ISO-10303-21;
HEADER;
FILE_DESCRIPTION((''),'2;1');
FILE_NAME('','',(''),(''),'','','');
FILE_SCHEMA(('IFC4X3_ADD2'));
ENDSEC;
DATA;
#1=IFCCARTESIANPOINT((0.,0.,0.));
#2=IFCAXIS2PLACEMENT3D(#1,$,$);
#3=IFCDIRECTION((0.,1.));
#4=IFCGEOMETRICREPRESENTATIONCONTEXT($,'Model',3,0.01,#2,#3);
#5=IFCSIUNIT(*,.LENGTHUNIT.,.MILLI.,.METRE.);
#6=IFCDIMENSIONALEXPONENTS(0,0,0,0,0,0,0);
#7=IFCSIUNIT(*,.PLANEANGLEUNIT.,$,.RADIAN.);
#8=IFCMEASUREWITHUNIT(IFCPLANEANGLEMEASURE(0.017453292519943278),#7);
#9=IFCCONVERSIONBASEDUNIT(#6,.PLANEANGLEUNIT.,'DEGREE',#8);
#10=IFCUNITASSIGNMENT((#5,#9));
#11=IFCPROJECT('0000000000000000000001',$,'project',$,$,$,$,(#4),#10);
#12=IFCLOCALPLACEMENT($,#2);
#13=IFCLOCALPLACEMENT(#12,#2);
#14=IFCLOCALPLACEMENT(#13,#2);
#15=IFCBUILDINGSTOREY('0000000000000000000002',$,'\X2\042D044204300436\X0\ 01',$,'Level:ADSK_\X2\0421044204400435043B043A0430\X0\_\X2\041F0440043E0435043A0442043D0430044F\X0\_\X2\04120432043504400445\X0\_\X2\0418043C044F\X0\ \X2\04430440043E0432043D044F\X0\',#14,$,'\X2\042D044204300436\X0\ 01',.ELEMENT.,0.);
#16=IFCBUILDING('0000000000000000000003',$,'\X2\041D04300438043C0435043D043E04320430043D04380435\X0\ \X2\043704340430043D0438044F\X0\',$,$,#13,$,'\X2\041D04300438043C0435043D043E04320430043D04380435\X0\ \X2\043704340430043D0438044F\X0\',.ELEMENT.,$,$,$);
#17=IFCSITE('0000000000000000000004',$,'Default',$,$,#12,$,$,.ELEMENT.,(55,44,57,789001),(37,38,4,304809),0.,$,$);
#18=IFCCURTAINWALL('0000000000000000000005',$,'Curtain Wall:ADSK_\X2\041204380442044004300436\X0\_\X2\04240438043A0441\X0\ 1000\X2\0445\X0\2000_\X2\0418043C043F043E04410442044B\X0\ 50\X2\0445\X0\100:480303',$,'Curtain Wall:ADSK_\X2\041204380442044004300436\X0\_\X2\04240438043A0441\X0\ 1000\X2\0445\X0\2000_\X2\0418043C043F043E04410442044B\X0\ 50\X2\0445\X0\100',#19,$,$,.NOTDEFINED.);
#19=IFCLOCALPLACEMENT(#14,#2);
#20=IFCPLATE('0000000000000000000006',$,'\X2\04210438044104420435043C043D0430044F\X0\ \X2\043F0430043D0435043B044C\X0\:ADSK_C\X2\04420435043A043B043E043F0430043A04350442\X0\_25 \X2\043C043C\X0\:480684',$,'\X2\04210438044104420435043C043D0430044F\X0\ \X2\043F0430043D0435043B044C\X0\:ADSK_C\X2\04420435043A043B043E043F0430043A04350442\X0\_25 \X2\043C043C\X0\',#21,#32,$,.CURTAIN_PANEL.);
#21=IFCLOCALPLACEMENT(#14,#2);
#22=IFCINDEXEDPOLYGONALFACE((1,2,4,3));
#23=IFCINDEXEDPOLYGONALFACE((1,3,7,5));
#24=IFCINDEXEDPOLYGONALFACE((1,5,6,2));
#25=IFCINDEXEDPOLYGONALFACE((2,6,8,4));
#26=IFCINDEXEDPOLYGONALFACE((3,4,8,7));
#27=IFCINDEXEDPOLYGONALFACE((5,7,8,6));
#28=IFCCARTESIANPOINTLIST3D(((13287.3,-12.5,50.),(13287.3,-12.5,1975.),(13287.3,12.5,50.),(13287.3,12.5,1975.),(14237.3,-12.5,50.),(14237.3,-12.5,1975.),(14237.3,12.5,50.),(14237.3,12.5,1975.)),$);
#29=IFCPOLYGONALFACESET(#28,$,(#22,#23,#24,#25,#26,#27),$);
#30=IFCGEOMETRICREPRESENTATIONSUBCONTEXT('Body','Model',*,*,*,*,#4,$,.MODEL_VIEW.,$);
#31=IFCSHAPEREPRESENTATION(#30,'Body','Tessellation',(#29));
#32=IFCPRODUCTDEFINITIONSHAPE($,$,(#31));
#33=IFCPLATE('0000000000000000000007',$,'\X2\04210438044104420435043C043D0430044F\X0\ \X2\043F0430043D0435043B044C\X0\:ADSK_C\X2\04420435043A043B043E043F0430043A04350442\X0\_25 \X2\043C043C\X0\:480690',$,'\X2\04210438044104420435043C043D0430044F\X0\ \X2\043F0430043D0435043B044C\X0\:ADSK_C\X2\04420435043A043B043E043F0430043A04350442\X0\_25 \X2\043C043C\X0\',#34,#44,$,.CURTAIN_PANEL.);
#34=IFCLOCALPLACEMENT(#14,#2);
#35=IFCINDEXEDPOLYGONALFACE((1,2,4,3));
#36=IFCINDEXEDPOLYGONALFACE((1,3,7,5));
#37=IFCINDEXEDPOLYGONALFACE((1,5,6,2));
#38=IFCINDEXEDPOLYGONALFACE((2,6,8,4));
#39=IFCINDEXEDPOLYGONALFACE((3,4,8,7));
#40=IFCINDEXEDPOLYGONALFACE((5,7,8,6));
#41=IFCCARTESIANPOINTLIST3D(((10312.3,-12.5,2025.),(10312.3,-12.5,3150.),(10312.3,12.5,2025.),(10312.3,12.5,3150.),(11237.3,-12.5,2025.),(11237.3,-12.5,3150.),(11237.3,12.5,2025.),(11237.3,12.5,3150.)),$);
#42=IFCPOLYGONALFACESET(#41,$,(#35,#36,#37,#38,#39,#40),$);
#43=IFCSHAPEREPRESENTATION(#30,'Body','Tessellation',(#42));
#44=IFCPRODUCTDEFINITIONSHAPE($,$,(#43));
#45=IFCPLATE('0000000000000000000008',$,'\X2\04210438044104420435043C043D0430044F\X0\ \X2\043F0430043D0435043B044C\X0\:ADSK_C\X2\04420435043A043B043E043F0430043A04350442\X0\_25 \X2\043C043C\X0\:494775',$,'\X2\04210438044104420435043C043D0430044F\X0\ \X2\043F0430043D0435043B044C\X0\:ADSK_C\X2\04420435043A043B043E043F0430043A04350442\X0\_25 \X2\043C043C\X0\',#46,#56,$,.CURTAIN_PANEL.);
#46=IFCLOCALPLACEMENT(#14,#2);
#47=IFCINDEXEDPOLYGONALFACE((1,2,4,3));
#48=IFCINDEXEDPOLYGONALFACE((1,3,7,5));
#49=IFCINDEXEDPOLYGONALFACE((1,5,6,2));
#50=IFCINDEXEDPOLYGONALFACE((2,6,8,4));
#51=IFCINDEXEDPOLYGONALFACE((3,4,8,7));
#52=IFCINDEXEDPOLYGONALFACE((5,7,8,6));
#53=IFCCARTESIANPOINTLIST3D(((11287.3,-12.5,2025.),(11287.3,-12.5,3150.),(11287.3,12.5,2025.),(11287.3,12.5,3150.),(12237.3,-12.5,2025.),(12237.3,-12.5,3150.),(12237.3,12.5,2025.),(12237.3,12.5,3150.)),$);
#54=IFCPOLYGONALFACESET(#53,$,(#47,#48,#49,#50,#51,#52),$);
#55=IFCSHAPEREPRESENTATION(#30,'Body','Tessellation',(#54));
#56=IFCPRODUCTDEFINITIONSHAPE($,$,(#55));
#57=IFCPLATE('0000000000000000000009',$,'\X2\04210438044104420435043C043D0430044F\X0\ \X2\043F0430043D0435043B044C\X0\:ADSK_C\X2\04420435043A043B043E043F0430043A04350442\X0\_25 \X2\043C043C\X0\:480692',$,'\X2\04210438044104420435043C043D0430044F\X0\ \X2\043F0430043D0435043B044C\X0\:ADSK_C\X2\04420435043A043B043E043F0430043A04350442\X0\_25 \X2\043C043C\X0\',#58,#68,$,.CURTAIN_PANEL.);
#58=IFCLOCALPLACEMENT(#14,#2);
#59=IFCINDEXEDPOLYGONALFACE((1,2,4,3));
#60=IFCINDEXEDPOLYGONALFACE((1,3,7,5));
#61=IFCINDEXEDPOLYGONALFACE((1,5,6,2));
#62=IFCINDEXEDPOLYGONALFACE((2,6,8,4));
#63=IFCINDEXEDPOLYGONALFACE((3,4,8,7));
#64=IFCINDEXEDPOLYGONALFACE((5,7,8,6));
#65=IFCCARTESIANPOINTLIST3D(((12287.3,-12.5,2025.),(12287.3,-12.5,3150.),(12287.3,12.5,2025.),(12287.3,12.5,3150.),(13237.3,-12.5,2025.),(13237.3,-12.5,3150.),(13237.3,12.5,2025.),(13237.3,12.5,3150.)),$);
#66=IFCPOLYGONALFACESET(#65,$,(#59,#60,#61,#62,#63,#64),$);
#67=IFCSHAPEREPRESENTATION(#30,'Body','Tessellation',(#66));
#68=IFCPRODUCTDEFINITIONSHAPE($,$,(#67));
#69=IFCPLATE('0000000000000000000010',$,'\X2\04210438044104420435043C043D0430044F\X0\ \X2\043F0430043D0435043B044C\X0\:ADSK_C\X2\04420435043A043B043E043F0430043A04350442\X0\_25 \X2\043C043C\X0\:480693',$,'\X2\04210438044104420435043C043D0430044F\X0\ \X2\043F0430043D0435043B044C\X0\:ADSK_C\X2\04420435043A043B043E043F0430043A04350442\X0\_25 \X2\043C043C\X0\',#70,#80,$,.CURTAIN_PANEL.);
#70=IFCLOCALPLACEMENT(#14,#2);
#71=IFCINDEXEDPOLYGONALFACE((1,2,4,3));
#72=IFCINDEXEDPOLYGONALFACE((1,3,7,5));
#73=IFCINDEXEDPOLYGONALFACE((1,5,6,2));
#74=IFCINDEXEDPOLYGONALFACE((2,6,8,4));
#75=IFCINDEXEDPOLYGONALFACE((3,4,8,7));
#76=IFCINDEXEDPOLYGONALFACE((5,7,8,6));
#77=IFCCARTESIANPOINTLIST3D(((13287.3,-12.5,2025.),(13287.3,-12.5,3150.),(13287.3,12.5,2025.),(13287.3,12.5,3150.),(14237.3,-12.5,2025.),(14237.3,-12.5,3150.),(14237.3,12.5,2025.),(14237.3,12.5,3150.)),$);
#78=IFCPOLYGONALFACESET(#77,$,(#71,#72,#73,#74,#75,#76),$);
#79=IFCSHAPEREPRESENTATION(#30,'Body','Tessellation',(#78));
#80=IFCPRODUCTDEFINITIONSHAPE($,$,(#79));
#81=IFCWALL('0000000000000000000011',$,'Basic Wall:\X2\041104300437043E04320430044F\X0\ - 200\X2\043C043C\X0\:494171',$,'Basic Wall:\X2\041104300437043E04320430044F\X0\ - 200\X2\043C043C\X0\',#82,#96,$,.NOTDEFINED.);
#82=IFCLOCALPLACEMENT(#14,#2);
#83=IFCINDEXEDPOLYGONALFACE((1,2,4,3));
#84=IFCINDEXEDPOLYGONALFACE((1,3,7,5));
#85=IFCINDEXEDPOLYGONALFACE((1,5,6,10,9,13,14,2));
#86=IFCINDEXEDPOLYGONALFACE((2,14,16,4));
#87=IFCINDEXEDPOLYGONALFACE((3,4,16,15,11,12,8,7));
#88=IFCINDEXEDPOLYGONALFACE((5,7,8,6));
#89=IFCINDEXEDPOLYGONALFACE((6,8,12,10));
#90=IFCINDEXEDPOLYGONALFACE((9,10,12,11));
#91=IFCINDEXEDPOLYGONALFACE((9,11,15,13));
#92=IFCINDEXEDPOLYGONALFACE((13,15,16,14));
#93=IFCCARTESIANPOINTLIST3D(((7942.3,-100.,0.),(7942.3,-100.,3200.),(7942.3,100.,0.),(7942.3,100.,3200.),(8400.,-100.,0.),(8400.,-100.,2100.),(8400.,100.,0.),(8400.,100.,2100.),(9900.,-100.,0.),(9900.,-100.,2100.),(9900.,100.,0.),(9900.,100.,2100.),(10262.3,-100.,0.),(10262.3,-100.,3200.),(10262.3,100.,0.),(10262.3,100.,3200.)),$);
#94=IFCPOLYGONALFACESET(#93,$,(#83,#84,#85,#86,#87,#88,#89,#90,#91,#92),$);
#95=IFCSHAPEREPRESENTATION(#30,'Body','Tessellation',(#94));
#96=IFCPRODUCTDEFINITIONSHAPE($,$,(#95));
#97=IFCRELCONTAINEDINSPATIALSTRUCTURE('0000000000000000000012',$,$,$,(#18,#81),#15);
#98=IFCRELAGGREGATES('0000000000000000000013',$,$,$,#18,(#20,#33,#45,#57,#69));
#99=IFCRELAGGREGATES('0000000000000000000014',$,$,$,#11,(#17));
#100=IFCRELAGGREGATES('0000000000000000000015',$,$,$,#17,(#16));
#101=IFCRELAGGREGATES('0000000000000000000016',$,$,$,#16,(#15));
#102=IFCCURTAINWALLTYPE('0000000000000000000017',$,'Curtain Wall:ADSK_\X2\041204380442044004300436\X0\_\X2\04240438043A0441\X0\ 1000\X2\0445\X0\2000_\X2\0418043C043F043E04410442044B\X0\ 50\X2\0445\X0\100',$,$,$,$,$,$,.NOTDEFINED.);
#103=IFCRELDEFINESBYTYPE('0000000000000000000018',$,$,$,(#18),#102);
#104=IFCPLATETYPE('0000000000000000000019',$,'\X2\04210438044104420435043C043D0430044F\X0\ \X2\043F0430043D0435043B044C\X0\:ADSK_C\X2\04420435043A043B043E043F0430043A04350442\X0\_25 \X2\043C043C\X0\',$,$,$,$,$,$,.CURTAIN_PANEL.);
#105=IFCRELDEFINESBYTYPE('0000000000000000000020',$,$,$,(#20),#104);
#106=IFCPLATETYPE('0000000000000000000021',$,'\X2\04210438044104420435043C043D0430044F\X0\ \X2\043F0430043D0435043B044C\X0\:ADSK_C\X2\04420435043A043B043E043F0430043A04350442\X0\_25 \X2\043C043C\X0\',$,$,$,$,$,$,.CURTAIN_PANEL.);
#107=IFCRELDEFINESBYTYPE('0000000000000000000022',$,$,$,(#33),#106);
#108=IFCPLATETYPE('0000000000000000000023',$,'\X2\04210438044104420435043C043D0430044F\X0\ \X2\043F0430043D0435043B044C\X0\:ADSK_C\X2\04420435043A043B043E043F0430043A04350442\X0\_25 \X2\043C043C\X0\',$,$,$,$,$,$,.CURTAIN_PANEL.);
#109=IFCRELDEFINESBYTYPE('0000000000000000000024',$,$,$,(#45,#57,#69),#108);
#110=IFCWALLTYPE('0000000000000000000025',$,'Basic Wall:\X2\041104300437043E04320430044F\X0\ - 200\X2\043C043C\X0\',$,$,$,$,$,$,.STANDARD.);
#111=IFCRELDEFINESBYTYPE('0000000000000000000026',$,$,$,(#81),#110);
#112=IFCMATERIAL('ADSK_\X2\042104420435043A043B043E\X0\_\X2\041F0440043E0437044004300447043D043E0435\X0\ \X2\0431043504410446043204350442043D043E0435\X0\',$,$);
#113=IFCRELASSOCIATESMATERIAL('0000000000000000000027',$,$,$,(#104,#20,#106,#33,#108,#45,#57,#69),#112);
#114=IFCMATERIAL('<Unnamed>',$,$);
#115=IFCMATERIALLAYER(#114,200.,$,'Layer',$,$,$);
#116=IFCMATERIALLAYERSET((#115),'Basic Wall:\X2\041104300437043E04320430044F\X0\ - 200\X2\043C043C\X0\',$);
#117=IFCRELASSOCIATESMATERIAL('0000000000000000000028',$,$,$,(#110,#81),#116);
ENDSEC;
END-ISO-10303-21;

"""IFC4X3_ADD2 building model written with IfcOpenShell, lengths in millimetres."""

from ifc_helpers import new_model, entity, si_unit, converted_unit, direction, frame, frame_2d, origin, origin_2d_with_axis, place, context, subcontext, project, spatial, rectangle, extrude, source, transform, mapped, material, layer, layer_set, type_object, type_shapes, element, aggregate, save


model = new_model("IFC4X3_ADD2")

# Units and contexts
model_context = context("Model", 3, precision=0.01, world=origin(), true_north=direction((0.0, 1.0)))
body_context = subcontext(model_context, "Body", "Model", "MODEL_VIEW")
ifc_project = project(units=[si_unit("LENGTHUNIT", "METRE", prefix="MILLI"), converted_unit("PLANEANGLEUNIT", "DEGREE", entity("IfcPlaneAngleMeasure", 0.017453292519943278), si_unit("PLANEANGLEUNIT", "RADIAN"), dimensions=[0, 0, 0, 0, 0, 0, 0])], contexts=[model_context])

# Site, building, storey
site_placement = place(None, origin())
site = spatial("IfcSite", under=ifc_project, at=site_placement, Name="Default", CompositionType="ELEMENT", RefLatitude=(55, 44, 57, 789001), RefLongitude=(37, 38, 4, 304809), RefElevation=0.0)
building_placement = place(site_placement, origin())
building = spatial("IfcBuilding", under=site, at=building_placement, Name="Наименование здания", LongName="Наименование здания", CompositionType="ELEMENT")
storey_placement = place(building_placement, origin())
storey = spatial("IfcBuildingStorey", under=building, at=storey_placement, Name="Этаж 01", ObjectType="Level:ADSK_Стрелка_Проектная_Вверх_Имя уровня", LongName="Этаж 01", CompositionType="ELEMENT", Elevation=0.0)

# Shared definitions
curtain_wall_type = type_object("IfcCurtainWallType", Name="Curtain Wall:ADSK_Витраж_Фикс 1000х2000_Импосты 50х100", PredefinedType="NOTDEFINED")
ifc_material_1 = material(Name="ADSK_Стекло_Прозрачное бесцветное")

# Curtain wall
curtain_wall_1_placement = place(storey_placement, origin())
curtain_wall_1 = element("IfcCurtainWall", 1, at=curtain_wall_1_placement, inside=storey, type_object=curtain_wall_type, Name="Curtain Wall:ADSK_Витраж_Фикс 1000х2000_Импосты 50х100:480303", ObjectType="Curtain Wall:ADSK_Витраж_Фикс 1000х2000_Импосты 50х100", PredefinedType="NOTDEFINED")

# Plates
plate_type_1 = type_object("IfcPlateType", Name="Системная панель:ADSK_Cтеклопакет_25 мм", PredefinedType="CURTAIN_PANEL", material=ifc_material_1)
shared_shape_1 = source(origin(), body_context, "Body", "SweptSolid", [
    extrude(rectangle(XDim=25.0, YDim=950.0, at=origin_2d_with_axis()), frame((0.0, 0.0, 0.0), z_axis=(0.0, 0.0, 1.0), x_axis=(0.0, 1.0, 0.0)), (0.0, 0.0, 1.0), 1925.0),
])
type_shapes(plate_type_1, [shared_shape_1])
plate_1_placement = place(curtain_wall_1_placement, frame((13762.3, 0.0, 50.0)))
plate_1 = element("IfcPlate", 2, at=plate_1_placement, type_object=plate_type_1, material=ifc_material_1, Name="Системная панель:ADSK_Cтеклопакет_25 мм:480684", ObjectType="Системная панель:ADSK_Cтеклопакет_25 мм", PredefinedType="CURTAIN_PANEL", context=body_context, shape_type="MappedRepresentation", body=[
    mapped(shared_shape_1, transform((0.0, 0.0, 0.0), scale=1.0)),
])
plate_type_2 = type_object("IfcPlateType", Name="Системная панель:ADSK_Cтеклопакет_25 мм", PredefinedType="CURTAIN_PANEL", material=ifc_material_1)
shared_shape_2 = source(origin(), body_context, "Body", "SweptSolid", [
    extrude(rectangle(XDim=25.0, YDim=925.0, at=origin_2d_with_axis()), frame((0.0, 0.0, 0.0), z_axis=(0.0, 0.0, 1.0), x_axis=(0.0, 1.0, 0.0)), (0.0, 0.0, 1.0), 1125.0),
])
type_shapes(plate_type_2, [shared_shape_2])
plate_2_placement = place(curtain_wall_1_placement, frame((10774.8, 0.0, 2025.0)))
plate_2 = element("IfcPlate", 3, at=plate_2_placement, type_object=plate_type_2, material=ifc_material_1, Name="Системная панель:ADSK_Cтеклопакет_25 мм:480690", ObjectType="Системная панель:ADSK_Cтеклопакет_25 мм", PredefinedType="CURTAIN_PANEL", context=body_context, shape_type="MappedRepresentation", body=[
    mapped(shared_shape_2, transform((0.0, 0.0, 0.0), scale=1.0)),
])
plate_type_3 = type_object("IfcPlateType", Name="Системная панель:ADSK_Cтеклопакет_25 мм", PredefinedType="CURTAIN_PANEL", material=ifc_material_1)
shared_shape_3 = source(origin(), body_context, "Body", "SweptSolid", [
    extrude(rectangle(XDim=25.0, YDim=950.0, at=origin_2d_with_axis()), frame((0.0, 0.0, 0.0), z_axis=(0.0, 0.0, 1.0), x_axis=(0.0, 1.0, 0.0)), (0.0, 0.0, 1.0), 1125.0),
])
type_shapes(plate_type_3, [shared_shape_3])
plate_3_placement = place(curtain_wall_1_placement, frame((11762.3, 0.0, 2025.0)))
plate_3 = element("IfcPlate", 4, at=plate_3_placement, type_object=plate_type_3, material=ifc_material_1, Name="Системная панель:ADSK_Cтеклопакет_25 мм:494775", ObjectType="Системная панель:ADSK_Cтеклопакет_25 мм", PredefinedType="CURTAIN_PANEL", context=body_context, shape_type="MappedRepresentation", body=[
    mapped(shared_shape_3, transform((0.0, 0.0, 0.0), scale=1.0)),
])
plate_4_placement = place(curtain_wall_1_placement, frame((12762.3, 0.0, 2025.0)))
plate_4 = element("IfcPlate", 5, at=plate_4_placement, type_object=plate_type_3, material=ifc_material_1, Name="Системная панель:ADSK_Cтеклопакет_25 мм:480692", ObjectType="Системная панель:ADSK_Cтеклопакет_25 мм", PredefinedType="CURTAIN_PANEL", context=body_context, shape_type="MappedRepresentation", body=[
    mapped(shared_shape_3, transform((0.0, 0.0, 0.0), scale=1.0)),
])
plate_5_placement = place(curtain_wall_1_placement, frame((13762.3, 0.0, 2025.0)))
plate_5 = element("IfcPlate", 6, at=plate_5_placement, type_object=plate_type_3, material=ifc_material_1, Name="Системная панель:ADSK_Cтеклопакет_25 мм:480693", ObjectType="Системная панель:ADSK_Cтеклопакет_25 мм", PredefinedType="CURTAIN_PANEL", context=body_context, shape_type="MappedRepresentation", body=[
    mapped(shared_shape_3, transform((0.0, 0.0, 0.0), scale=1.0)),
])
aggregate(curtain_wall_1, [plate_1, plate_2, plate_3, plate_4, plate_5])

# Wall, opening
ifc_material_2 = material(Name="<Unnamed>")
ifc_layer = layer(ifc_material_2, 200.0, Name="Layer")
ifc_layer_set = layer_set([ifc_layer], Name="Basic Wall:Базовая - 200мм")
wall_type = type_object("IfcWallType", Name="Basic Wall:Базовая - 200мм", PredefinedType="STANDARD", material=ifc_layer_set)
wall_placement = place(storey_placement, frame((7942.3, 0.0, 0.0)))
wall = element("IfcWall", 7, at=wall_placement, inside=storey, type_object=wall_type, material=ifc_layer_set, Name="Basic Wall:Базовая - 200мм:494171", ObjectType="Basic Wall:Базовая - 200мм", PredefinedType="NOTDEFINED", context=body_context, shape_type="SweptSolid", body=[
    extrude(rectangle(XDim=2320.0, YDim=200.0, at=frame_2d((1160.0, 0.0), x_axis=(1.0, 0.0))), origin(), (0.0, 0.0, 1.0), 3200.0),
])
opening_placement = place(wall_placement, frame((-7942.3, 0.0, 0.0)))
element("IfcOpeningElement", 8, at=opening_placement, cuts=wall, PredefinedType="OPENING", context=body_context, shape_type="SweptSolid", body=[
    extrude(rectangle(XDim=2100.0, YDim=1500.0, at=frame_2d((0.0, 0.0), x_axis=(0.0, 1.0))), frame((9150.0, -600.0, 1050.0), z_axis=(0.0, 1.0, 0.0), x_axis=(1.0, 0.0, 0.0)), (0.0, 0.0, 1.0), 1200.0),
])

save(model, "model.ifc")
